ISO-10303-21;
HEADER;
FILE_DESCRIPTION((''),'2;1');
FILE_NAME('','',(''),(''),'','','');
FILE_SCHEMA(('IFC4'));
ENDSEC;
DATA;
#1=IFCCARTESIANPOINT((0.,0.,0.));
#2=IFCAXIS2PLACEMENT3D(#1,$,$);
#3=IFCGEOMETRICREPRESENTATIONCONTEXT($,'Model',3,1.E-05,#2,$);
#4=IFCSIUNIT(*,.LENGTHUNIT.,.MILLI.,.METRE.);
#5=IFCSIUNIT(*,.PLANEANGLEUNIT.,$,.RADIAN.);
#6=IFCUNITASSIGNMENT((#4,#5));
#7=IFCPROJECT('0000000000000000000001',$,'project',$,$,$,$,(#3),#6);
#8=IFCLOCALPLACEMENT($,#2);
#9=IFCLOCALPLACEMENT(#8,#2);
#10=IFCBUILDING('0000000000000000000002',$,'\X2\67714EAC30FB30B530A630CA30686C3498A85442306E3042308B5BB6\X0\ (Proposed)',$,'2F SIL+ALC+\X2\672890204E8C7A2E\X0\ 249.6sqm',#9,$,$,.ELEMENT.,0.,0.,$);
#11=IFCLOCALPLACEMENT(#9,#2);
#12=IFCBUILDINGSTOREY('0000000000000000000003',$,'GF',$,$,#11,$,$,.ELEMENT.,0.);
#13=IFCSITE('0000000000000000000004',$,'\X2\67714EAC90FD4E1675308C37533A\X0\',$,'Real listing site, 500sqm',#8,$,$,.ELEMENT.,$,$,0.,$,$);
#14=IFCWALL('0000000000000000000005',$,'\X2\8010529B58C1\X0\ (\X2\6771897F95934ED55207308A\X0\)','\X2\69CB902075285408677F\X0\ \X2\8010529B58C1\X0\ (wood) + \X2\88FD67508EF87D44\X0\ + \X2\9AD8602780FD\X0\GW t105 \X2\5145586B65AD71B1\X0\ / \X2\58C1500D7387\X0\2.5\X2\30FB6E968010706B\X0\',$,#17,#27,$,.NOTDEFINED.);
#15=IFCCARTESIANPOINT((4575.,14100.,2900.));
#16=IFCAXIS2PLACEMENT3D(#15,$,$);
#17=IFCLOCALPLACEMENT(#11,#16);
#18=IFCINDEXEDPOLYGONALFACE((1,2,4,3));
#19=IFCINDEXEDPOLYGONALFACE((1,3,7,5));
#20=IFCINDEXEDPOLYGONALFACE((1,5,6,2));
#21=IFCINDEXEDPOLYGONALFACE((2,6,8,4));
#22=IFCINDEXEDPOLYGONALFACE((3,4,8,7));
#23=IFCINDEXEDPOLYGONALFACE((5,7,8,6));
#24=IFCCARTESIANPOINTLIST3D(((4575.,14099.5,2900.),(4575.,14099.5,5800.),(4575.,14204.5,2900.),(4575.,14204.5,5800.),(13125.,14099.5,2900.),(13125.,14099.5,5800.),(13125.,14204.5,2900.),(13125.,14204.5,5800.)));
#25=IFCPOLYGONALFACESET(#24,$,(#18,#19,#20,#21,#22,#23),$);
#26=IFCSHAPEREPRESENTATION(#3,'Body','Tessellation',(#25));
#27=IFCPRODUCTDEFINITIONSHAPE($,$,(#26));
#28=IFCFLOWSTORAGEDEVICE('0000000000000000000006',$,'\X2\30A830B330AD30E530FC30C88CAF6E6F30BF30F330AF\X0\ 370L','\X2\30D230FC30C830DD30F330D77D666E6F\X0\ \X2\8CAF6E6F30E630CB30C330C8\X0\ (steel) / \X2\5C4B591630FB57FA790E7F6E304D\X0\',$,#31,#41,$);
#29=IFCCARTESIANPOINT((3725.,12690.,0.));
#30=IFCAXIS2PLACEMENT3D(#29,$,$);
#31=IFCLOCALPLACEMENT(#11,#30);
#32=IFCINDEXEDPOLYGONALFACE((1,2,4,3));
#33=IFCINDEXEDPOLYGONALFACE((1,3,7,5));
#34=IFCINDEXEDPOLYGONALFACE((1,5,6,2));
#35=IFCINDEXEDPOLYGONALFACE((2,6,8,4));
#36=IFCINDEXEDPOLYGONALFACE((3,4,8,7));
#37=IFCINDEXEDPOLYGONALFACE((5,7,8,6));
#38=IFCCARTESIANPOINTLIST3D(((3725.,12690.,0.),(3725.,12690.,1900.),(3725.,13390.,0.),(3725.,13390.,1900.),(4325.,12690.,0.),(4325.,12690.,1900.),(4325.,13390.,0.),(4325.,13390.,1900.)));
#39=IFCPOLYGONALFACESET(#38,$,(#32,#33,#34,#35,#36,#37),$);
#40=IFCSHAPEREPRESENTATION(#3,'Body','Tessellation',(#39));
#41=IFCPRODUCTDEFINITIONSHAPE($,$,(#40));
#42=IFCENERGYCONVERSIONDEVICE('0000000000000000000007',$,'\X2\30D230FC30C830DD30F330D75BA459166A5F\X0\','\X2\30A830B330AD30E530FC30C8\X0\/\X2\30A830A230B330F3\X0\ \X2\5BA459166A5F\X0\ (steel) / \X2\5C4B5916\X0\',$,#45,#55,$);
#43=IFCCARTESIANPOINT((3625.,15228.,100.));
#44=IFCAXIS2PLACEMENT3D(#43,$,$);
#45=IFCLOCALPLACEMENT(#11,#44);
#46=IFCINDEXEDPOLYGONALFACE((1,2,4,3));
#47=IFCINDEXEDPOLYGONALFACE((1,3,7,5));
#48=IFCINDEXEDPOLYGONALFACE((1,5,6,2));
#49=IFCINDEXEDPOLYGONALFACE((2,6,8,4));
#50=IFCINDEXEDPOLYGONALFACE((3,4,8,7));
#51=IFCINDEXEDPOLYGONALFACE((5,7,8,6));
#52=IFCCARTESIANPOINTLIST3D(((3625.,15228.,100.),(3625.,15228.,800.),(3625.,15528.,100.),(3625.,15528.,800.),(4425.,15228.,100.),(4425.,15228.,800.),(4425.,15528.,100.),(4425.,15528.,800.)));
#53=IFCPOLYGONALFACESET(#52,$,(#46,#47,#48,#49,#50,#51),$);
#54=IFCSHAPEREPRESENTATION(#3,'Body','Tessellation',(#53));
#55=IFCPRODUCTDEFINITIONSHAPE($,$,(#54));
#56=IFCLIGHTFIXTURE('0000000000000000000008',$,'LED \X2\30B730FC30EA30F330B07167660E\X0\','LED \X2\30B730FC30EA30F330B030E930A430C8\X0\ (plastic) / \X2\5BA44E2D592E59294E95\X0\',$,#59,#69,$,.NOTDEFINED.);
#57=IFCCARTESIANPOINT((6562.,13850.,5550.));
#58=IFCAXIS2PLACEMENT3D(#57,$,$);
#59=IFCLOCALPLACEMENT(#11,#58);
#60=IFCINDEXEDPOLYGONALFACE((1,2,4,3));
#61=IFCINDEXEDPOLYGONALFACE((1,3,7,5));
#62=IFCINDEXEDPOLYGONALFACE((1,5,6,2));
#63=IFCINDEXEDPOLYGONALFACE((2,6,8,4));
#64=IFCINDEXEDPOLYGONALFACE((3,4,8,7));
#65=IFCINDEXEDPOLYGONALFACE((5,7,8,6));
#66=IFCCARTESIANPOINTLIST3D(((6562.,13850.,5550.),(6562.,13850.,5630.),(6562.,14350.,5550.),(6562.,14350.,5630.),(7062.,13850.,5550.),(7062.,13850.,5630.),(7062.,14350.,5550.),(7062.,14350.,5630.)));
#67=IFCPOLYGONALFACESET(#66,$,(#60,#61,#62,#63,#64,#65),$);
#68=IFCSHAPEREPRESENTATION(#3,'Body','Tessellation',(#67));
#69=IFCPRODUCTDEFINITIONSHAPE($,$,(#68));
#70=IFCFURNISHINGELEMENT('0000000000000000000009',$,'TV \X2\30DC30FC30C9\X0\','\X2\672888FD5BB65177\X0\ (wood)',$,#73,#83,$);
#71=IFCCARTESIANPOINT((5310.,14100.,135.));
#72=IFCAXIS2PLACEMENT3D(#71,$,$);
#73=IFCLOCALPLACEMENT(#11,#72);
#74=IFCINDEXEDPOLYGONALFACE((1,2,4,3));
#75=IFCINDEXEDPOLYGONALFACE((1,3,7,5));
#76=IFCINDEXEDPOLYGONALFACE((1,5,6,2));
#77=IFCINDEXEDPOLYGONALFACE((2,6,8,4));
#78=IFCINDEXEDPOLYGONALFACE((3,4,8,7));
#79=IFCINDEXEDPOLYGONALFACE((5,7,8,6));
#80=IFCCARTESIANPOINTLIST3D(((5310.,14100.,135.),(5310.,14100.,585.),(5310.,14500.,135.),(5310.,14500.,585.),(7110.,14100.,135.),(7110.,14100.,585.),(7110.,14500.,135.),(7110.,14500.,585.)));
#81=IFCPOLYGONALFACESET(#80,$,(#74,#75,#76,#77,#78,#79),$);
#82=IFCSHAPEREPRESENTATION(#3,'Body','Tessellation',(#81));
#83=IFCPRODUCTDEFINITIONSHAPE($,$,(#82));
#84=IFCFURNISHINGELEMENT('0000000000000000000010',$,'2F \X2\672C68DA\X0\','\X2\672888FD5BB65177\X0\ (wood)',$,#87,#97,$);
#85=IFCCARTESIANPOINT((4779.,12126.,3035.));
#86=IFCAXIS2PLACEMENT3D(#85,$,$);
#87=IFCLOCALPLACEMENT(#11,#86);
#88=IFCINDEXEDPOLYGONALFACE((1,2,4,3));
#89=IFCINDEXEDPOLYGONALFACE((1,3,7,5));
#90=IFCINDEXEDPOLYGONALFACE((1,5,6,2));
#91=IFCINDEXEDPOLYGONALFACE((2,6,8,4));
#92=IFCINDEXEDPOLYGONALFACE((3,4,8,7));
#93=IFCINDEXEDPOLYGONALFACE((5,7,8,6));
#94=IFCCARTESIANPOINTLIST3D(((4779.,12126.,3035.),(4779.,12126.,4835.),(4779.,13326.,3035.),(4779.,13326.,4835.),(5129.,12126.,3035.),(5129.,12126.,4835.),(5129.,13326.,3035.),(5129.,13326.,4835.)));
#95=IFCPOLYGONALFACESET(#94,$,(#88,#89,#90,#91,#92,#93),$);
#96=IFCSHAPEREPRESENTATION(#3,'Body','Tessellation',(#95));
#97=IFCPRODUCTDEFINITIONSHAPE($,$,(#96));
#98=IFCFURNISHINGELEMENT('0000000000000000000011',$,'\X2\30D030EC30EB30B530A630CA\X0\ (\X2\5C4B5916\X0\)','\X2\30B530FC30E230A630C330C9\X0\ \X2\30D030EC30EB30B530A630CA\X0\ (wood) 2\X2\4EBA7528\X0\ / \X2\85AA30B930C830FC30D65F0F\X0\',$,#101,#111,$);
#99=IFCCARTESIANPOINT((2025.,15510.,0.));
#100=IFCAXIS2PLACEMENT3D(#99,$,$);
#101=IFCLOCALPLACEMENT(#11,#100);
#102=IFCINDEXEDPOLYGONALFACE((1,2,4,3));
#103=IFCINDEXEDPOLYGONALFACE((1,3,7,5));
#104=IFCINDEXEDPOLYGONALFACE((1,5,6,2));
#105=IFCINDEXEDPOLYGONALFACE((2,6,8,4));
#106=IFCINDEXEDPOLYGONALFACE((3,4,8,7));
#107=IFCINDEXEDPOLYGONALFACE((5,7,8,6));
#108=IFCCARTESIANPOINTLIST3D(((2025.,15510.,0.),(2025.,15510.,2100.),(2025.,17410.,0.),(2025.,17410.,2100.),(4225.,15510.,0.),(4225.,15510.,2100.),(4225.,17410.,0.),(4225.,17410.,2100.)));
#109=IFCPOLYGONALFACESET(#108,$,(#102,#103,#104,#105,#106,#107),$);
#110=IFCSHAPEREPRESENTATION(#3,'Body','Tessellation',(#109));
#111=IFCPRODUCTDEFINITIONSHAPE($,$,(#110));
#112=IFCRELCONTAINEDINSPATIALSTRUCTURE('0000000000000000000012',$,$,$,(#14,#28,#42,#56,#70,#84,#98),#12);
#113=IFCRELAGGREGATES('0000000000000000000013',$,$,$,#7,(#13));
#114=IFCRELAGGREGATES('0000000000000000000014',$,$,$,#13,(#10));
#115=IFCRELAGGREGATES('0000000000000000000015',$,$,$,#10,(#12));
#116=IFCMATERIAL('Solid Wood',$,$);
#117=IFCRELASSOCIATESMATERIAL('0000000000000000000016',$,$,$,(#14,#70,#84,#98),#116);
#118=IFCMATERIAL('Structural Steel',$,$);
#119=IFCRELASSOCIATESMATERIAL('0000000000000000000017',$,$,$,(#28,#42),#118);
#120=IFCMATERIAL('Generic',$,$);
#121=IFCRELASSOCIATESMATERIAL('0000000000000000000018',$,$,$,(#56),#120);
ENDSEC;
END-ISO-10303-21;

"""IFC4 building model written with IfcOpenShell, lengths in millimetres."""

from ifc_helpers import new_model, si_unit, frame, frame_2d, origin, place, context, project, spatial, rectangle, extrude, material, element, save


model = new_model("IFC4")

# Units and contexts
model_context = context("Model", 3, precision=1e-05, world=origin())
ifc_project = project(units=[si_unit("LENGTHUNIT", "METRE", prefix="MILLI"), si_unit("PLANEANGLEUNIT", "RADIAN")], contexts=[model_context])

# Site, building, storey
site_placement = place(None, origin())
site = spatial("IfcSite", under=ifc_project, at=site_placement, Name="東京都世田谷区", ObjectType="Real listing site, 500sqm", CompositionType="ELEMENT", RefElevation=0.0)
building_placement = place(site_placement, origin())
building = spatial("IfcBuilding", under=site, at=building_placement, Name="東京・サウナと水風呂のある家 (Proposed)", ObjectType="2F SIL+ALC+木造二種 249.6sqm", CompositionType="ELEMENT", ElevationOfRefHeight=0.0, ElevationOfTerrain=0.0)
storey_placement = place(building_placement, origin())
storey = spatial("IfcBuildingStorey", under=building, at=storey_placement, Name="GF", CompositionType="ELEMENT", Elevation=0.0)

# Shared definitions
ifc_material_1 = material(Name="Solid Wood")

# Wall
wall_1_placement = place(storey_placement, frame((4575.0, 14100.0, 2900.0)))
element("IfcWall", 1, at=wall_1_placement, inside=storey, material=ifc_material_1, Name="耐力壁 (東西間仕切り)", Description="構造用合板 耐力壁 (wood) + 製材軸組 + 高性能GW t105 充填断熱 / 壁倍率2.5・準耐火", PredefinedType="NOTDEFINED", context=model_context, shape_type="SweptSolid", body=[
    extrude(rectangle(XDim=8550.0, YDim=105.0, at=frame_2d((4275.0, 52.0))), frame((4575.0, 14100.0, 2900.0)), (0.0, 0.0, 1.0), 2900.0),
])

# Flow storage device
ifc_material_2 = material(Name="Structural Steel")
flow_storage_device_placement = place(storey_placement, frame((3725.0, 12690.0, 0.0)))
element("IfcFlowStorageDevice", 2, at=flow_storage_device_placement, inside=storey, material=ifc_material_2, Name="エコキュート貯湯タンク 370L", Description="ヒートポンプ給湯 貯湯ユニット (steel) / 屋外・基礎置き", context=model_context, shape_type="SweptSolid", body=[
    extrude(rectangle(XDim=600.0, YDim=700.0, at=frame_2d((300.0, 350.0))), frame((3725.0, 12690.0, 0.0)), (0.0, 0.0, 1.0), 1900.0),
])

# Energy conversion device
energy_conversion_device_placement = place(storey_placement, frame((3625.0, 15228.0, 100.0)))
element("IfcEnergyConversionDevice", 3, at=energy_conversion_device_placement, inside=storey, material=ifc_material_2, Name="ヒートポンプ室外機", Description="エコキュート/エアコン 室外機 (steel) / 屋外", context=model_context, shape_type="SweptSolid", body=[
    extrude(rectangle(XDim=800.0, YDim=300.0, at=frame_2d((400.0, 150.0))), frame((3625.0, 15228.0, 100.0)), (0.0, 0.0, 1.0), 700.0),
])

# Light fixture
ifc_material_3 = material(Name="Generic")
light_fixture_placement = place(storey_placement, frame((6562.0, 13850.0, 5550.0)))
element("IfcLightFixture", 4, at=light_fixture_placement, inside=storey, material=ifc_material_3, Name="LED シーリング照明", Description="LED シーリングライト (plastic) / 室中央天井", PredefinedType="NOTDEFINED", context=model_context, shape_type="SweptSolid", body=[
    extrude(rectangle(XDim=500.0, YDim=500.0, at=frame_2d((250.0, 250.0))), frame((6562.0, 13850.0, 5550.0)), (0.0, 0.0, 1.0), 80.0),
])

# Furnishing elements
furnishing_1_placement = place(storey_placement, frame((5310.0, 14100.0, 135.0)))
element("IfcFurnishingElement", 5, at=furnishing_1_placement, inside=storey, material=ifc_material_1, Name="TV ボード", Description="木製家具 (wood)", context=model_context, shape_type="SweptSolid", body=[
    extrude(rectangle(XDim=1800.0, YDim=400.0, at=frame_2d((900.0, 200.0))), frame((5310.0, 14100.0, 135.0)), (0.0, 0.0, 1.0), 450.0),
])
furnishing_2_placement = place(storey_placement, frame((4779.0, 12126.0, 3035.0)))
element("IfcFurnishingElement", 6, at=furnishing_2_placement, inside=storey, material=ifc_material_1, Name="2F 本棚", Description="木製家具 (wood)", context=model_context, shape_type="SweptSolid", body=[
    extrude(rectangle(XDim=350.0, YDim=1200.0, at=frame_2d((175.0, 600.0))), frame((4779.0, 12126.0, 3035.0)), (0.0, 0.0, 1.0), 1800.0),
])
furnishing_3_placement = place(storey_placement, frame((2025.0, 15510.0, 0.0)))
element("IfcFurnishingElement", 7, at=furnishing_3_placement, inside=storey, material=ifc_material_1, Name="バレルサウナ (屋外)", Description="サーモウッド バレルサウナ (wood) 2人用 / 薪ストーブ式", context=model_context, shape_type="SweptSolid", body=[
    extrude(rectangle(XDim=2200.0, YDim=1900.0, at=frame_2d((1100.0, 950.0))), frame((2025.0, 15510.0, 0.0)), (0.0, 0.0, 1.0), 2100.0),
])

save(model, "model.ifc")
